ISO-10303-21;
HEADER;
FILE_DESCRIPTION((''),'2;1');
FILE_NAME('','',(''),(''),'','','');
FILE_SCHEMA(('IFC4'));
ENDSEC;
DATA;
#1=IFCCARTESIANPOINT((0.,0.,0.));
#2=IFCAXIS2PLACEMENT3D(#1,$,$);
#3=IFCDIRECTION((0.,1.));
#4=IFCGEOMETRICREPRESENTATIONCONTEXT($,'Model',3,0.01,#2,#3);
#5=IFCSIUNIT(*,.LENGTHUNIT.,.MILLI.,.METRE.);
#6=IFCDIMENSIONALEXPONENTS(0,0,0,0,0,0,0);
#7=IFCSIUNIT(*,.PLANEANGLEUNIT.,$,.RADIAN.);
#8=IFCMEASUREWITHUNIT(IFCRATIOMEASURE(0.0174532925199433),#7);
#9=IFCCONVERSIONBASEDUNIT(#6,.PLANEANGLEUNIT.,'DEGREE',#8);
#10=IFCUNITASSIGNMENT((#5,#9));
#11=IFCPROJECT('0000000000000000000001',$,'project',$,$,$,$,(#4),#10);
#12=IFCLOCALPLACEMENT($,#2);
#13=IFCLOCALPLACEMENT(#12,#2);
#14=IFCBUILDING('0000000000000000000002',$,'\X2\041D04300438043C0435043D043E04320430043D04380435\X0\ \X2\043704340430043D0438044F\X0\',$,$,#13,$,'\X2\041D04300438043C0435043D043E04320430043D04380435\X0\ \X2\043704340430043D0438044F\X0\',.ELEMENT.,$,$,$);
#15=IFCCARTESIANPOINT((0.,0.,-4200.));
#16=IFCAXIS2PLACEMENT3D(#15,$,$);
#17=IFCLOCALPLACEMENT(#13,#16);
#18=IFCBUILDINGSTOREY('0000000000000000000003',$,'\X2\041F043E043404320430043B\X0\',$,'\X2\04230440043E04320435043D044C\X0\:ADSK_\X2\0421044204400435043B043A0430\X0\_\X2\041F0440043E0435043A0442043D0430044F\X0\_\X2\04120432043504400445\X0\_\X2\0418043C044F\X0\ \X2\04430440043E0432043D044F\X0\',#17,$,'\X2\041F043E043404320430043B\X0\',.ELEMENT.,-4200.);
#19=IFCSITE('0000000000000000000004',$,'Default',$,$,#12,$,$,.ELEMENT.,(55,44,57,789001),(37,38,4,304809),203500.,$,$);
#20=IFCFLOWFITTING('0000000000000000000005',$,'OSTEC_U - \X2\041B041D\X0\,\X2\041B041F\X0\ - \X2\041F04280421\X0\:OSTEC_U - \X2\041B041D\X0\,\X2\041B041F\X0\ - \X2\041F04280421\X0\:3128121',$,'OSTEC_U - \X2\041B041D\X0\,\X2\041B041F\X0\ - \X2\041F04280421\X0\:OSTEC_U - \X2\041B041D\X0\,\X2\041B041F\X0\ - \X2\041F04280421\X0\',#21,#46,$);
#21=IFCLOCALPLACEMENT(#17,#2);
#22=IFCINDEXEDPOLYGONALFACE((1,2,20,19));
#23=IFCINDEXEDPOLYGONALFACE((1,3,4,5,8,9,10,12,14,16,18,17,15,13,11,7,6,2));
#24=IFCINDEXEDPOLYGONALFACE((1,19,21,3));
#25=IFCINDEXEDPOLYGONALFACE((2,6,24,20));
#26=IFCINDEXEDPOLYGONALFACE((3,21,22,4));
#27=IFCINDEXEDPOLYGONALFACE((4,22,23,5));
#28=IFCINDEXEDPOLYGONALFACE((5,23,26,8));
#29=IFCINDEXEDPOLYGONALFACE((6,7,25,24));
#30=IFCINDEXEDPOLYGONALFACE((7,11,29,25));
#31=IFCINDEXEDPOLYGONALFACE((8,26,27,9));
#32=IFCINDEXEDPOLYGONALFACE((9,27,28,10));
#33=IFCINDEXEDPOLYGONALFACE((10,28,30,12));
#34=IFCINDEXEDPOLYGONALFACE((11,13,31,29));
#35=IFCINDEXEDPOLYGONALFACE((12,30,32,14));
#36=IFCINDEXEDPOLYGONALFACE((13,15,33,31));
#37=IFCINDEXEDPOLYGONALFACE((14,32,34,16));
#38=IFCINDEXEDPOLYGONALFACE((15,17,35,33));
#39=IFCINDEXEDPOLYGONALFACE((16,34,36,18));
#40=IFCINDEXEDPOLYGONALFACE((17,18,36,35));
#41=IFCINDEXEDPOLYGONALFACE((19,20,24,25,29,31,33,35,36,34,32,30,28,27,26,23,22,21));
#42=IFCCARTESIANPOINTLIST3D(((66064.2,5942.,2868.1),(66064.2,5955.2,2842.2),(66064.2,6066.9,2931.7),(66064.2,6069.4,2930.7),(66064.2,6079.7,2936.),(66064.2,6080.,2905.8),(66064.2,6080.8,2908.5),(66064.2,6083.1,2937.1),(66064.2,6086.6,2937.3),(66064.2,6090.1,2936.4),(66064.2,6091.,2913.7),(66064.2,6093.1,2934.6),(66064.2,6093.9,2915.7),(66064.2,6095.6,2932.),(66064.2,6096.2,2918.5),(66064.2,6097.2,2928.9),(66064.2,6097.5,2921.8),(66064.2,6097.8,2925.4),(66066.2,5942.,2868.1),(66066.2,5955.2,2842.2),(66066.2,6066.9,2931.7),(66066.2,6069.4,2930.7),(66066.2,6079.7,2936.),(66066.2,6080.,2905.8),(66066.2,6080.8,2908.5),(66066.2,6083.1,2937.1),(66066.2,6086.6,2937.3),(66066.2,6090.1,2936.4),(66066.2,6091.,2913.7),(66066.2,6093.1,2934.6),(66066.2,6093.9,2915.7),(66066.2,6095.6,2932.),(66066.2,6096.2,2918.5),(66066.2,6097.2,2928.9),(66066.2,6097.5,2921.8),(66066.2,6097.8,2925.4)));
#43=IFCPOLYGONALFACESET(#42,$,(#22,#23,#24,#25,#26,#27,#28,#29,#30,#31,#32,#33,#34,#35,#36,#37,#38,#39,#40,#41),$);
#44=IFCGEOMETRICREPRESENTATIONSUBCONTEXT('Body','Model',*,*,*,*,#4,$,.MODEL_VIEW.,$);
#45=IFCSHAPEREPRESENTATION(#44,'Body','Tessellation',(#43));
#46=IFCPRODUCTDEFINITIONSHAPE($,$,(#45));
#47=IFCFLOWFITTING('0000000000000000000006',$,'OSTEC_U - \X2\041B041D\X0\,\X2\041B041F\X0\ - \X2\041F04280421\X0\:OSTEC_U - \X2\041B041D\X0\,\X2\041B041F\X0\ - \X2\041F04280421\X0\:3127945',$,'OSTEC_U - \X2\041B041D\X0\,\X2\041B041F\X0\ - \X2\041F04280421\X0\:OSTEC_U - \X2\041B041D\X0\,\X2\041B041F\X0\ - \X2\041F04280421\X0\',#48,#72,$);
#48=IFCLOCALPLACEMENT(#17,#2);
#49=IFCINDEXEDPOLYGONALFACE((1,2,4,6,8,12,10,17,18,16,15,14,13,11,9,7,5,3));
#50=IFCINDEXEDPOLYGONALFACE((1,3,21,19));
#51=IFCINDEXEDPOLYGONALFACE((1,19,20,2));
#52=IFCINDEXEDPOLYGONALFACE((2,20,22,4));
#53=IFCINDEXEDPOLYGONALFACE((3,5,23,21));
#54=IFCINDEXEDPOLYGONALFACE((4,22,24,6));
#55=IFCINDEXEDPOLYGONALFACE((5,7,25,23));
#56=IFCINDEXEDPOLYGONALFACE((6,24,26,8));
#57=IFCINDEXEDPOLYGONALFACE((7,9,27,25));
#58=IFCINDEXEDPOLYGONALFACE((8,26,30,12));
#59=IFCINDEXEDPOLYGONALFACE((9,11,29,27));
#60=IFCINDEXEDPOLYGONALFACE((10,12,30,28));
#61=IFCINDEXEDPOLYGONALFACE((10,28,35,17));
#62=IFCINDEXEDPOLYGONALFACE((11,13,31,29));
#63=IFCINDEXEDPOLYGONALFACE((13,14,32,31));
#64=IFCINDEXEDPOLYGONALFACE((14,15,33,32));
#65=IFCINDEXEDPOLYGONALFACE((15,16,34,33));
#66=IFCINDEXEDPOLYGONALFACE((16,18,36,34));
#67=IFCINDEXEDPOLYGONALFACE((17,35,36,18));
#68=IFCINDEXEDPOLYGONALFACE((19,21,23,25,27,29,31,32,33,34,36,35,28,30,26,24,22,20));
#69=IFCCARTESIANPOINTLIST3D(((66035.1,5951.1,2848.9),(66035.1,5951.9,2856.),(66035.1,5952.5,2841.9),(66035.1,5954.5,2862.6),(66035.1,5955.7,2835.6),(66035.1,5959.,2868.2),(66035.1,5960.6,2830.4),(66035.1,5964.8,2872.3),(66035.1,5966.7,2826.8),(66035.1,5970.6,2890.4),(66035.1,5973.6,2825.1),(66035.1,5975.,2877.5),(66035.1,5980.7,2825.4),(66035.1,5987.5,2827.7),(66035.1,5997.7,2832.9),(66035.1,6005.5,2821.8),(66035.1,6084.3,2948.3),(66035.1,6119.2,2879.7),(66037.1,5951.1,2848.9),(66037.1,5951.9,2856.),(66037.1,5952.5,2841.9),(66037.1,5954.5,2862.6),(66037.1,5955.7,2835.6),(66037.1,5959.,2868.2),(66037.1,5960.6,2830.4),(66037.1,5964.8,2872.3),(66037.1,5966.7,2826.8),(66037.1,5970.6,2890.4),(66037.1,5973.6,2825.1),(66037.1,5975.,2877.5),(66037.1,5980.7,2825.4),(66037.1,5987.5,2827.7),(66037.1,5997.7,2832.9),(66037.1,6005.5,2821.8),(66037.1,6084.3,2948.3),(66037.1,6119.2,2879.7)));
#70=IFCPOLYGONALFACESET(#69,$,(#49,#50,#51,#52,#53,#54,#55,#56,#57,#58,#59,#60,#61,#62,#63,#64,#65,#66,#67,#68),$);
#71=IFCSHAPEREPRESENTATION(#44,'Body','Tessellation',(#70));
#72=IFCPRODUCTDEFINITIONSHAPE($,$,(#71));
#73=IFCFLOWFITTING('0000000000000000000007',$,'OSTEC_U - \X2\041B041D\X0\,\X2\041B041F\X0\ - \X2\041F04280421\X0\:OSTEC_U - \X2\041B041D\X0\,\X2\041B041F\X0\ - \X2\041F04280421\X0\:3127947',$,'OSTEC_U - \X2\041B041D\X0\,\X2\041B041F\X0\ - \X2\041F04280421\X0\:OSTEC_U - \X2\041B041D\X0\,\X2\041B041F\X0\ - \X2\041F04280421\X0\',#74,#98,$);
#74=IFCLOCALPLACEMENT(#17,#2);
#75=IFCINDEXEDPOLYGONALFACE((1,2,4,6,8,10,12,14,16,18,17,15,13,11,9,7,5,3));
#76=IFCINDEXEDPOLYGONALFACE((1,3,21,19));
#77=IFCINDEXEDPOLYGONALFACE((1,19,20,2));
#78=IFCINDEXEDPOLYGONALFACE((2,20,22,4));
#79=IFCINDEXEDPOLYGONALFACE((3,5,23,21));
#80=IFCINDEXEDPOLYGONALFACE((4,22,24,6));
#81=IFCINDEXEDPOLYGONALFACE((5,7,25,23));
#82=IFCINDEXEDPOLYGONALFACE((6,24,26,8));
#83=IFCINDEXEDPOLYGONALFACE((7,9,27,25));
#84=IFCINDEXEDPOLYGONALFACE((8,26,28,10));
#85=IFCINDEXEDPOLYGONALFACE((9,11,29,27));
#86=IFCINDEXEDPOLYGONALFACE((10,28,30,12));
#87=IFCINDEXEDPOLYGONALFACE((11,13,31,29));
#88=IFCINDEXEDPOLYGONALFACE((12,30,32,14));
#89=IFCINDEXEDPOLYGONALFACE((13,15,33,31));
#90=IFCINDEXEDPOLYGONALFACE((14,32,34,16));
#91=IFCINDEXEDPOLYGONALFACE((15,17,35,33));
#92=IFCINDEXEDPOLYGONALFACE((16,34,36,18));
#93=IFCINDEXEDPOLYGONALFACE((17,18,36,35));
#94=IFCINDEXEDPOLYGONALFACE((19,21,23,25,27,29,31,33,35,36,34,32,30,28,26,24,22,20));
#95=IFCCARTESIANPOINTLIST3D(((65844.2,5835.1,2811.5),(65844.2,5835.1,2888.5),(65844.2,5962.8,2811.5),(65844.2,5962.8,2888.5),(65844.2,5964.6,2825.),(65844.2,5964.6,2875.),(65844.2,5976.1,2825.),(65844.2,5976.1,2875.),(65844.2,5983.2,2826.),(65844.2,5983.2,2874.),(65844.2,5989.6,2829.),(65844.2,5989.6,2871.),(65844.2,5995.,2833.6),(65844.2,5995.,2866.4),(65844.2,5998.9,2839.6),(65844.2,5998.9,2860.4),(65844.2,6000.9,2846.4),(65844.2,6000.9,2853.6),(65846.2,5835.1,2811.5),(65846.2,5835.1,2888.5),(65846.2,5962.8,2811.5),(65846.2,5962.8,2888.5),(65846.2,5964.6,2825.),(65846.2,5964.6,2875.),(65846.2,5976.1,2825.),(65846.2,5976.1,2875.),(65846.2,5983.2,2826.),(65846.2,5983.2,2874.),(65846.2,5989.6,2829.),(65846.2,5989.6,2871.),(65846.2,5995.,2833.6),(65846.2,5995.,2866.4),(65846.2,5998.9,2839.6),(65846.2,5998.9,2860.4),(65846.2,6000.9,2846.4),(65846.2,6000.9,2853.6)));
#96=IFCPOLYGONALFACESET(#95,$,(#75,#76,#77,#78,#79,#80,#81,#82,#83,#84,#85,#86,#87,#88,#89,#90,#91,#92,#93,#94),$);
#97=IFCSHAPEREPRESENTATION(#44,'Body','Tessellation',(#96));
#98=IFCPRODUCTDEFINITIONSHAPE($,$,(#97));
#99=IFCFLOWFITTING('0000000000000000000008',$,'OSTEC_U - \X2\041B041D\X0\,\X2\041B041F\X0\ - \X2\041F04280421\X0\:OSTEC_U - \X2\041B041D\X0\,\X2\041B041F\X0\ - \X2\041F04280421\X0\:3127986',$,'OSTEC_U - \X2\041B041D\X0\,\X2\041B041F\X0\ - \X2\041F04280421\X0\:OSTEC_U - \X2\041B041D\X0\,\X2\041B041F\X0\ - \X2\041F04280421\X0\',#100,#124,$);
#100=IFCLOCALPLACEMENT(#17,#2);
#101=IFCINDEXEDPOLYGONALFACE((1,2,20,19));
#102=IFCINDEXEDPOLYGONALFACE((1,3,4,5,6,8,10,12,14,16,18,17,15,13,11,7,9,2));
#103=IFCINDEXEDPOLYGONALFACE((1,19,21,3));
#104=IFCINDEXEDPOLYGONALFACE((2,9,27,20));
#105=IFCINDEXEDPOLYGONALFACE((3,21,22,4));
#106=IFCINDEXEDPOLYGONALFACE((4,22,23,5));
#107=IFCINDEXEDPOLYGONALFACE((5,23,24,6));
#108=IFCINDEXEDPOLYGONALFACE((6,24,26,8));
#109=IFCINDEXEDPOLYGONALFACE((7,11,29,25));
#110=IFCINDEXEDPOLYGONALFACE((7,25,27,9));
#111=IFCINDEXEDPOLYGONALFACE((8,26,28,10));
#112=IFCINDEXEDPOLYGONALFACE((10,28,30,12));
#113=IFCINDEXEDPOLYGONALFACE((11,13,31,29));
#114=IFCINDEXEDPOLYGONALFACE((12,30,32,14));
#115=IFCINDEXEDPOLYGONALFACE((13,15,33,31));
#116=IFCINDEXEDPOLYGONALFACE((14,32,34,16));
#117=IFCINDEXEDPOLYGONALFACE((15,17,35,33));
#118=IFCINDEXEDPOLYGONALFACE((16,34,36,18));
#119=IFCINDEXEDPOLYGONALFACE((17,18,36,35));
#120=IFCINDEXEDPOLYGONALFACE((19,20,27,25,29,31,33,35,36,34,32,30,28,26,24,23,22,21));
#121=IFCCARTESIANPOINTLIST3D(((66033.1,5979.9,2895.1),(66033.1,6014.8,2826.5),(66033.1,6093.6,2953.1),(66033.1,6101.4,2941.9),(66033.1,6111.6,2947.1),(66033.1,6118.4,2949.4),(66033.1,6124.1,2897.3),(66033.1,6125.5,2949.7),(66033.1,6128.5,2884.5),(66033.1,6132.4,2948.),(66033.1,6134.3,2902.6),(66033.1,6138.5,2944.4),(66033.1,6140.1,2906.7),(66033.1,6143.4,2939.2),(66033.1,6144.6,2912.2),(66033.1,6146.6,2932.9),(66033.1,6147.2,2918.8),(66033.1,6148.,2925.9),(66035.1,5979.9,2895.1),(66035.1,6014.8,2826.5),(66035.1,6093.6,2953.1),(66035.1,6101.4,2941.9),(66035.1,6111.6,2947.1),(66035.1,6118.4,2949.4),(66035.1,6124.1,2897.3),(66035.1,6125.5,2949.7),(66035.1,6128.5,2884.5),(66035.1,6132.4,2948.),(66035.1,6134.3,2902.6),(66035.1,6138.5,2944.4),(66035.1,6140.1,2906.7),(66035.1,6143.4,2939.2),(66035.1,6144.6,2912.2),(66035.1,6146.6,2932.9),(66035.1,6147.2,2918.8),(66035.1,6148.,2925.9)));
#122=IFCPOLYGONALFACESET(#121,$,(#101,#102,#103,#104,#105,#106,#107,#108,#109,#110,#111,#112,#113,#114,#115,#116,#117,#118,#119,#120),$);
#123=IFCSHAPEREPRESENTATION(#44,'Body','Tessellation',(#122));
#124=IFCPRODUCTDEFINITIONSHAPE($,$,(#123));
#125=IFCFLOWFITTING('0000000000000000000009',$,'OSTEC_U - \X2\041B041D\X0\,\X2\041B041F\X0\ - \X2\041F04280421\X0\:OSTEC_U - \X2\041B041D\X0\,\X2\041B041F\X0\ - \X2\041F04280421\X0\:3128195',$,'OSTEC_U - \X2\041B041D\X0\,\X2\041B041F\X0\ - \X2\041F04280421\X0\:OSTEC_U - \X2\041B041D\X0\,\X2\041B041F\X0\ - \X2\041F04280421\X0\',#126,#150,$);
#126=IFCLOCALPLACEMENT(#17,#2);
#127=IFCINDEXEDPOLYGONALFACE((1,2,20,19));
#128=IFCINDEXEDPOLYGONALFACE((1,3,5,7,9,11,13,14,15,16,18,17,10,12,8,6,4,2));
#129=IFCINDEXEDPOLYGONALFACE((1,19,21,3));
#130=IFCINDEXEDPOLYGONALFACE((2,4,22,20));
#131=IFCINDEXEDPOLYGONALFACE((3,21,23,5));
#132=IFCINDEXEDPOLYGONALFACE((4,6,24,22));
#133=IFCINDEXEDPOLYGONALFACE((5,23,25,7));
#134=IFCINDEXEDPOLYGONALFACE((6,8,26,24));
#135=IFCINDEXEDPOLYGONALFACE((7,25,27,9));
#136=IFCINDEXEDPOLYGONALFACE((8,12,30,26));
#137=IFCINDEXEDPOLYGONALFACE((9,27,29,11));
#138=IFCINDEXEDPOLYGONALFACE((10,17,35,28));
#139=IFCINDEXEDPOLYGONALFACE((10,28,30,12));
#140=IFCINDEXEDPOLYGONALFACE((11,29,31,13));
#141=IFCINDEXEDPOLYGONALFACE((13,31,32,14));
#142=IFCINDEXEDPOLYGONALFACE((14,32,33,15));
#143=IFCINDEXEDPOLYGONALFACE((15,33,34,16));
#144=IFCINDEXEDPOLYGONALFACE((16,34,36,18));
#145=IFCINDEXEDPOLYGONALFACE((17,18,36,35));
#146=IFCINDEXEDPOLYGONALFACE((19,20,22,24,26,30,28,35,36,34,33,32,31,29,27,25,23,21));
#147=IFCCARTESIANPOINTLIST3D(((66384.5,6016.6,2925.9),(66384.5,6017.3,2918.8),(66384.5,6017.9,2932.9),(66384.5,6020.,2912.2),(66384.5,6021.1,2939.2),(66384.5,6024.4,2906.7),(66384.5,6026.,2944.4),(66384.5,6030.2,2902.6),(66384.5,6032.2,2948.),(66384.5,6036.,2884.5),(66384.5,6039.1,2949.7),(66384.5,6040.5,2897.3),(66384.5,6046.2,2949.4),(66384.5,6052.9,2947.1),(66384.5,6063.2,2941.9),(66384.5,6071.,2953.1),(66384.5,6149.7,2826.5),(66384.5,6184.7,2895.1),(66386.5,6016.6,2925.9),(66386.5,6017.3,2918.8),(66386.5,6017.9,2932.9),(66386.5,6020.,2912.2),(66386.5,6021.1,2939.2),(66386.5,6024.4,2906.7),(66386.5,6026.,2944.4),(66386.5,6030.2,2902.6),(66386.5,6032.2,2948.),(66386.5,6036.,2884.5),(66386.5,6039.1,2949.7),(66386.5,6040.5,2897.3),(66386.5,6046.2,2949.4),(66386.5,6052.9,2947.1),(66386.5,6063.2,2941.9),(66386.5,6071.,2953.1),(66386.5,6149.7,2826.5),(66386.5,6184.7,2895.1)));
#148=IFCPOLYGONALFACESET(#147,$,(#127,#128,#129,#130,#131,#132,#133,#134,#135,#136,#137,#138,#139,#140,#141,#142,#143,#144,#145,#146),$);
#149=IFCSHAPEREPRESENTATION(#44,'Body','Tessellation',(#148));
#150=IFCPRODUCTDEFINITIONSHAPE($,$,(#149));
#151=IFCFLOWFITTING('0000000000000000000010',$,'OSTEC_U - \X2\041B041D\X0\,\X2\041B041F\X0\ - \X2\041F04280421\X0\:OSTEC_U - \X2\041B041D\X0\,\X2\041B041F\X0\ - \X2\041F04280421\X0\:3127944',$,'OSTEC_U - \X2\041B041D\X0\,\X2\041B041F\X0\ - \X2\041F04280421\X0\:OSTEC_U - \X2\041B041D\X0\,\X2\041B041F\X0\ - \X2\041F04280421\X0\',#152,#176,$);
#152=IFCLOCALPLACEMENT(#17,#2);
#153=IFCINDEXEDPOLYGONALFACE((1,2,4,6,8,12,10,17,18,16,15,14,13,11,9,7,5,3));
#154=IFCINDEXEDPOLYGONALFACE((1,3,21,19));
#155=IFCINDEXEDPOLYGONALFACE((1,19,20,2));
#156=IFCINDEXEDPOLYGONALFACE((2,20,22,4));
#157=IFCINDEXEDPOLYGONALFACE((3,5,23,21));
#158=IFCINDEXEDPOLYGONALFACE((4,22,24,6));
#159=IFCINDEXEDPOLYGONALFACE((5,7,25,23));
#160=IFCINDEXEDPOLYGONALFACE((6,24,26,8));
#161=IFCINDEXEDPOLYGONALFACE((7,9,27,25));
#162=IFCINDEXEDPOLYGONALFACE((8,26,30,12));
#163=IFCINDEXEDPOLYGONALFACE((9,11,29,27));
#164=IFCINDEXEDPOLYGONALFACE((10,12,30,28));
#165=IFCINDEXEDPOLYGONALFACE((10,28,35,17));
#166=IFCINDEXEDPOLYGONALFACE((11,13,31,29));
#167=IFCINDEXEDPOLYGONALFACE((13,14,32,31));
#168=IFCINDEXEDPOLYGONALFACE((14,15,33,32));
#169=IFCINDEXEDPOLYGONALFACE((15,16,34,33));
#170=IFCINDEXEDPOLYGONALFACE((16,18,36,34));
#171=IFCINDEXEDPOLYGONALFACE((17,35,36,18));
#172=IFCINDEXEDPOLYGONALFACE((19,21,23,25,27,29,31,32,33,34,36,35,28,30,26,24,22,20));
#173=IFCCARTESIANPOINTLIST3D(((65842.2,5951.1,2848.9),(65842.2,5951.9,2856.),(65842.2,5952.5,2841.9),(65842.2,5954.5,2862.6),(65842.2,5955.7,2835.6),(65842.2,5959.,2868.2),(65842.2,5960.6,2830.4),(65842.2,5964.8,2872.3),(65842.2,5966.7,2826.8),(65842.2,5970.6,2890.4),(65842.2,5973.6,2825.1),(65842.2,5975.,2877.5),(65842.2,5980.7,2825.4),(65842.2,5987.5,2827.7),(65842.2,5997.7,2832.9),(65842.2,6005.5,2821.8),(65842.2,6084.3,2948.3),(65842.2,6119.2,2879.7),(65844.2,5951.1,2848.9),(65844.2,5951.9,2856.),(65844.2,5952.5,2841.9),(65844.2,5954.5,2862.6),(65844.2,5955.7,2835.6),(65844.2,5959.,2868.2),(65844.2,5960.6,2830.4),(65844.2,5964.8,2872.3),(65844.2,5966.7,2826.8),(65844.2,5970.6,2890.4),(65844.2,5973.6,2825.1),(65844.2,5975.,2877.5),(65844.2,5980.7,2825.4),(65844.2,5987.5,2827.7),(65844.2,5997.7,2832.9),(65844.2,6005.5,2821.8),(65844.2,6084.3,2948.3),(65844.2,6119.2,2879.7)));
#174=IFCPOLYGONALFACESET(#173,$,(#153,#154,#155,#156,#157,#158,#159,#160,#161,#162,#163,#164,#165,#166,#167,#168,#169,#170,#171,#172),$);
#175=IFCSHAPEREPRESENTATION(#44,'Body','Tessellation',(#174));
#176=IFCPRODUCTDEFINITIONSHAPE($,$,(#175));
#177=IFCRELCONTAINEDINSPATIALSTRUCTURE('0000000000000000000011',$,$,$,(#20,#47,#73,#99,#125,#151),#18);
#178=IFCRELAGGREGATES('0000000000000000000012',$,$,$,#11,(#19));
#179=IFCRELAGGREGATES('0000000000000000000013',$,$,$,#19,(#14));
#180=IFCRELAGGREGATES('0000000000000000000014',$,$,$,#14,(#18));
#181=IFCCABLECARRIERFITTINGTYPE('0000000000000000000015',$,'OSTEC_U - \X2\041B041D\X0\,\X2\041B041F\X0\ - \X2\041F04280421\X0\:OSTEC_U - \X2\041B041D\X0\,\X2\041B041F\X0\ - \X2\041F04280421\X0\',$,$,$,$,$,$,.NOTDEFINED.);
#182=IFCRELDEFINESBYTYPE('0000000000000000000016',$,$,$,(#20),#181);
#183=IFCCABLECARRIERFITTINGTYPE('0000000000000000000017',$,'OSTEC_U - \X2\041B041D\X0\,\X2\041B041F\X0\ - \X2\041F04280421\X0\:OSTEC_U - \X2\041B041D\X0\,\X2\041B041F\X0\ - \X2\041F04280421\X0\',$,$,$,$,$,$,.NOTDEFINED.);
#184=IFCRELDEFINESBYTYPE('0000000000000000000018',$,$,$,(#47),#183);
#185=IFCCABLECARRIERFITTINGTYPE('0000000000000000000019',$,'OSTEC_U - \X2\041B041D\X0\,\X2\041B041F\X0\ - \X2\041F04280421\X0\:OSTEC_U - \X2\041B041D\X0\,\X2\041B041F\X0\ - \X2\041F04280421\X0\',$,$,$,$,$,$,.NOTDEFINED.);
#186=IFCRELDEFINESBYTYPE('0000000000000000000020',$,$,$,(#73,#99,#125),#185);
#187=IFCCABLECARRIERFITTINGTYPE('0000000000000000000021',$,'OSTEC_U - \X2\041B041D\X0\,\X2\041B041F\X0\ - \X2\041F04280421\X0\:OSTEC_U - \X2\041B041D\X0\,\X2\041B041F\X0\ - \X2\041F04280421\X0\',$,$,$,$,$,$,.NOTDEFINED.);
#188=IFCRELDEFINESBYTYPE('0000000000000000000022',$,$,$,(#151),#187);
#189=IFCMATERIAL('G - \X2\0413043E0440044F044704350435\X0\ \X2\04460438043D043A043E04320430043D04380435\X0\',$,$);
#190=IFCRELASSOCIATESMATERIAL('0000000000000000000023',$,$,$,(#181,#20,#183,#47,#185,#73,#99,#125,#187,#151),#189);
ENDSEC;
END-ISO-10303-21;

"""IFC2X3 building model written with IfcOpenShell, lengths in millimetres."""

from ifc_helpers import new_model, entity, si_unit, converted_unit, direction, frame, frame_2d, origin, place, context, subcontext, project, spatial, polyline, circle_curve, parameter, trimmed, segment, composite_curve, outline, extrude, source, transform, mapped, material, type_object, type_shapes, element, save


model = new_model("IFC2X3")

# Units and contexts
model_context = context("Model", 3, precision=0.01, world=origin(), true_north=direction((0.0, 1.0)))
body_context = subcontext(model_context, "Body", "Model", "MODEL_VIEW")
ifc_project = project(units=[si_unit("LENGTHUNIT", "METRE", prefix="MILLI"), converted_unit("PLANEANGLEUNIT", "DEGREE", entity("IfcRatioMeasure", 0.0174532925199433), si_unit("PLANEANGLEUNIT", "RADIAN"), dimensions=[0, 0, 0, 0, 0, 0, 0])], contexts=[model_context])

# Site, building, storey
site_placement = place(None, origin())
site = spatial("IfcSite", under=ifc_project, at=site_placement, Name="Default", CompositionType="ELEMENT", RefLatitude=(55, 44, 57, 789001), RefLongitude=(37, 38, 4, 304809), RefElevation=203500.0)
building_placement = place(site_placement, origin())
building = spatial("IfcBuilding", under=site, at=building_placement, Name="Наименование здания", LongName="Наименование здания", CompositionType="ELEMENT")
storey_placement = place(building_placement, frame((0.0, 0.0, -4200.0)))
storey = spatial("IfcBuildingStorey", under=building, at=storey_placement, Name="Подвал", ObjectType="Уровень:ADSK_Стрелка_Проектная_Вверх_Имя уровня", LongName="Подвал", CompositionType="ELEMENT", Elevation=-4200.0)

# Flow fittings
ifc_material = material(Name="G - Горячее цинкование")
shared_shape_1 = source(origin(), body_context, "Body", "SweptSolid", [
    extrude(outline(composite_curve([segment(trimmed(circle_curve(frame_2d((-44.6, 0.0), x_axis=(1.0, 0.0)), 12.5), [parameter(90.0)], [parameter(270.0)], True, "PARAMETER"), True, "CONTINUOUS"), segment(polyline([(-44.6, -12.5), (-33.1, -12.5)]), True, "CONTINUOUS"), segment(polyline([(-33.1, -12.5), (-31.2, -14.5)]), True, "CONTINUOUS"), segment(polyline([(-31.2, -14.5), (108.9, -14.5)]), True, "CONTINUOUS"), segment(polyline([(108.9, -14.5), (108.9, 14.5)]), True, "CONTINUOUS"), segment(polyline([(108.9, 14.5), (-31.2, 14.5)]), True, "CONTINUOUS"), segment(polyline([(-31.2, 14.5), (-33.1, 12.5)]), True, "CONTINUOUS"), segment(polyline([(-33.1, 12.5), (-44.6, 12.5)]), True, "CONTINUOUS")], self_intersect=False)), frame((44.6, 0.0, 0.0)), (0.0, 0.0, 1.0), 2.0),
])
cable_carrier_fitting_type_1 = type_object("IfcCableCarrierFittingType", Name="OSTEC_U - ЛН,ЛП - ПШС:OSTEC_U - ЛН,ЛП - ПШС", PredefinedType="NOTDEFINED", material=ifc_material)
type_shapes(cable_carrier_fitting_type_1, [shared_shape_1])
flow_fitting_1_placement = place(storey_placement, frame((66066.2, 6085.4, 2924.8), z_axis=(-1.0, 0.0, 0.0), x_axis=(0.0, -0.891007, -0.45399)))
element("IfcFlowFitting", 1, at=flow_fitting_1_placement, inside=storey, type_object=cable_carrier_fitting_type_1, material=ifc_material, Name="OSTEC_U - ЛН,ЛП - ПШС:OSTEC_U - ЛН,ЛП - ПШС:3128121", ObjectType="OSTEC_U - ЛН,ЛП - ПШС:OSTEC_U - ЛН,ЛП - ПШС", context=body_context, shape_type="MappedRepresentation", body=[
    mapped(shared_shape_1, transform((0.0, 0.0, 0.0), scale=1.0)),
])
cable_carrier_fitting_type_2 = type_object("IfcCableCarrierFittingType", Name="OSTEC_U - ЛН,ЛП - ПШС:OSTEC_U - ЛН,ЛП - ПШС", PredefinedType="NOTDEFINED", material=ifc_material)
shared_shape_2 = source(origin(), body_context, "Body", "SweptSolid", [
    extrude(outline(composite_curve([segment(trimmed(circle_curve(frame_2d((-41.5, 0.0), x_axis=(1.0, 0.0)), 25.0), [parameter(90.0)], [parameter(270.0)], True, "PARAMETER"), True, "CONTINUOUS"), segment(polyline([(-41.5, -25.0), (-30.0, -25.0)]), True, "CONTINUOUS"), segment(polyline([(-30.0, -25.0), (-28.1, -38.5)]), True, "CONTINUOUS"), segment(polyline([(-28.1, -38.5), (99.5, -38.5)]), True, "CONTINUOUS"), segment(polyline([(99.5, -38.5), (99.5, 38.5)]), True, "CONTINUOUS"), segment(polyline([(99.5, 38.5), (-28.1, 38.5)]), True, "CONTINUOUS"), segment(polyline([(-28.1, 38.5), (-30.0, 25.0)]), True, "CONTINUOUS"), segment(polyline([(-30.0, 25.0), (-41.5, 25.0)]), True, "CONTINUOUS")], self_intersect=False)), frame((41.5, 0.0, 0.0), z_axis=(0.0, 0.0, -1.0), x_axis=(1.0, 0.0, 0.0)), (0.0, 0.0, -1.0), 2.0),
])
type_shapes(cable_carrier_fitting_type_2, [shared_shape_2])
flow_fitting_2_placement = place(storey_placement, frame((66035.1, 5976.1, 2850.0), z_axis=(1.0, 0.0, 0.0), x_axis=(0.0, 0.891007, 0.45399)))
element("IfcFlowFitting", 2, at=flow_fitting_2_placement, inside=storey, type_object=cable_carrier_fitting_type_2, material=ifc_material, Name="OSTEC_U - ЛН,ЛП - ПШС:OSTEC_U - ЛН,ЛП - ПШС:3127945", ObjectType="OSTEC_U - ЛН,ЛП - ПШС:OSTEC_U - ЛН,ЛП - ПШС", context=body_context, shape_type="MappedRepresentation", body=[
    mapped(shared_shape_2, transform((0.0, 0.0, 0.0), scale=1.0)),
])
cable_carrier_fitting_type_3 = type_object("IfcCableCarrierFittingType", Name="OSTEC_U - ЛН,ЛП - ПШС:OSTEC_U - ЛН,ЛП - ПШС", PredefinedType="NOTDEFINED", material=ifc_material)
type_shapes(cable_carrier_fitting_type_3, [shared_shape_2])
flow_fitting_3_placement = place(storey_placement, frame((65846.2, 5976.1, 2850.0), z_axis=(-1.0, 0.0, 0.0), x_axis=(0.0, -1.0, 0.0)))
element("IfcFlowFitting", 3, at=flow_fitting_3_placement, inside=storey, type_object=cable_carrier_fitting_type_3, material=ifc_material, Name="OSTEC_U - ЛН,ЛП - ПШС:OSTEC_U - ЛН,ЛП - ПШС:3127947", ObjectType="OSTEC_U - ЛН,ЛП - ПШС:OSTEC_U - ЛН,ЛП - ПШС", context=body_context, shape_type="MappedRepresentation", body=[
    mapped(shared_shape_2, transform((0.0, 0.0, 0.0), scale=1.0)),
])
for number, where, z_axis, x_axis, name in (
    (4, (66033.1, 6123.0, 2924.8), (1.0, 0.0, 0.0), (0.0, -0.891007, -0.45399), "OSTEC_U - ЛН,ЛП - ПШС:OSTEC_U - ЛН,ЛП - ПШС:3127986"),
    (5, (66386.5, 6041.6, 2924.8), (-1.0, 0.0, 0.0), (0.0, 0.891007, -0.45399), "OSTEC_U - ЛН,ЛП - ПШС:OSTEC_U - ЛН,ЛП - ПШС:3128195"),
):
    element("IfcFlowFitting", number, at=place(storey_placement, frame(where, z_axis=z_axis, x_axis=x_axis)), inside=storey, type_object=cable_carrier_fitting_type_3, material=ifc_material, Name=name, ObjectType="OSTEC_U - ЛН,ЛП - ПШС:OSTEC_U - ЛН,ЛП - ПШС", context=body_context, shape_type="MappedRepresentation", body=[
        mapped(shared_shape_2, transform((0.0, 0.0, 0.0), scale=1.0)),
    ])
cable_carrier_fitting_type_4 = type_object("IfcCableCarrierFittingType", Name="OSTEC_U - ЛН,ЛП - ПШС:OSTEC_U - ЛН,ЛП - ПШС", PredefinedType="NOTDEFINED", material=ifc_material)
shared_shape_3 = source(origin(), body_context, "Body", "SweptSolid", [
    extrude(outline(composite_curve([segment(trimmed(circle_curve(frame_2d((-41.5, 0.0), x_axis=(1.0, 0.0)), 25.0), [parameter(90.0)], [parameter(270.0)], True, "PARAMETER"), True, "CONTINUOUS"), segment(polyline([(-41.5, -25.0), (-30.0, -25.0)]), True, "CONTINUOUS"), segment(polyline([(-30.0, -25.0), (-28.1, -38.5)]), True, "CONTINUOUS"), segment(polyline([(-28.1, -38.5), (99.5, -38.5)]), True, "CONTINUOUS"), segment(polyline([(99.5, -38.5), (99.5, 38.5)]), True, "CONTINUOUS"), segment(polyline([(99.5, 38.5), (-28.1, 38.5)]), True, "CONTINUOUS"), segment(polyline([(-28.1, 38.5), (-30.0, 25.0)]), True, "CONTINUOUS"), segment(polyline([(-30.0, 25.0), (-41.5, 25.0)]), True, "CONTINUOUS")], self_intersect=False)), frame((41.5, 0.0, 0.0)), (0.0, 0.0, 1.0), 2.0),
])
type_shapes(cable_carrier_fitting_type_4, [shared_shape_3])
flow_fitting_4_placement = place(storey_placement, frame((65844.2, 5976.1, 2850.0), z_axis=(-1.0, 0.0, 0.0), x_axis=(0.0, 0.891007, 0.45399)))
element("IfcFlowFitting", 6, at=flow_fitting_4_placement, inside=storey, type_object=cable_carrier_fitting_type_4, material=ifc_material, Name="OSTEC_U - ЛН,ЛП - ПШС:OSTEC_U - ЛН,ЛП - ПШС:3127944", ObjectType="OSTEC_U - ЛН,ЛП - ПШС:OSTEC_U - ЛН,ЛП - ПШС", context=body_context, shape_type="MappedRepresentation", body=[
    mapped(shared_shape_3, transform((0.0, 0.0, 0.0), scale=1.0)),
])

save(model, "model.ifc")
